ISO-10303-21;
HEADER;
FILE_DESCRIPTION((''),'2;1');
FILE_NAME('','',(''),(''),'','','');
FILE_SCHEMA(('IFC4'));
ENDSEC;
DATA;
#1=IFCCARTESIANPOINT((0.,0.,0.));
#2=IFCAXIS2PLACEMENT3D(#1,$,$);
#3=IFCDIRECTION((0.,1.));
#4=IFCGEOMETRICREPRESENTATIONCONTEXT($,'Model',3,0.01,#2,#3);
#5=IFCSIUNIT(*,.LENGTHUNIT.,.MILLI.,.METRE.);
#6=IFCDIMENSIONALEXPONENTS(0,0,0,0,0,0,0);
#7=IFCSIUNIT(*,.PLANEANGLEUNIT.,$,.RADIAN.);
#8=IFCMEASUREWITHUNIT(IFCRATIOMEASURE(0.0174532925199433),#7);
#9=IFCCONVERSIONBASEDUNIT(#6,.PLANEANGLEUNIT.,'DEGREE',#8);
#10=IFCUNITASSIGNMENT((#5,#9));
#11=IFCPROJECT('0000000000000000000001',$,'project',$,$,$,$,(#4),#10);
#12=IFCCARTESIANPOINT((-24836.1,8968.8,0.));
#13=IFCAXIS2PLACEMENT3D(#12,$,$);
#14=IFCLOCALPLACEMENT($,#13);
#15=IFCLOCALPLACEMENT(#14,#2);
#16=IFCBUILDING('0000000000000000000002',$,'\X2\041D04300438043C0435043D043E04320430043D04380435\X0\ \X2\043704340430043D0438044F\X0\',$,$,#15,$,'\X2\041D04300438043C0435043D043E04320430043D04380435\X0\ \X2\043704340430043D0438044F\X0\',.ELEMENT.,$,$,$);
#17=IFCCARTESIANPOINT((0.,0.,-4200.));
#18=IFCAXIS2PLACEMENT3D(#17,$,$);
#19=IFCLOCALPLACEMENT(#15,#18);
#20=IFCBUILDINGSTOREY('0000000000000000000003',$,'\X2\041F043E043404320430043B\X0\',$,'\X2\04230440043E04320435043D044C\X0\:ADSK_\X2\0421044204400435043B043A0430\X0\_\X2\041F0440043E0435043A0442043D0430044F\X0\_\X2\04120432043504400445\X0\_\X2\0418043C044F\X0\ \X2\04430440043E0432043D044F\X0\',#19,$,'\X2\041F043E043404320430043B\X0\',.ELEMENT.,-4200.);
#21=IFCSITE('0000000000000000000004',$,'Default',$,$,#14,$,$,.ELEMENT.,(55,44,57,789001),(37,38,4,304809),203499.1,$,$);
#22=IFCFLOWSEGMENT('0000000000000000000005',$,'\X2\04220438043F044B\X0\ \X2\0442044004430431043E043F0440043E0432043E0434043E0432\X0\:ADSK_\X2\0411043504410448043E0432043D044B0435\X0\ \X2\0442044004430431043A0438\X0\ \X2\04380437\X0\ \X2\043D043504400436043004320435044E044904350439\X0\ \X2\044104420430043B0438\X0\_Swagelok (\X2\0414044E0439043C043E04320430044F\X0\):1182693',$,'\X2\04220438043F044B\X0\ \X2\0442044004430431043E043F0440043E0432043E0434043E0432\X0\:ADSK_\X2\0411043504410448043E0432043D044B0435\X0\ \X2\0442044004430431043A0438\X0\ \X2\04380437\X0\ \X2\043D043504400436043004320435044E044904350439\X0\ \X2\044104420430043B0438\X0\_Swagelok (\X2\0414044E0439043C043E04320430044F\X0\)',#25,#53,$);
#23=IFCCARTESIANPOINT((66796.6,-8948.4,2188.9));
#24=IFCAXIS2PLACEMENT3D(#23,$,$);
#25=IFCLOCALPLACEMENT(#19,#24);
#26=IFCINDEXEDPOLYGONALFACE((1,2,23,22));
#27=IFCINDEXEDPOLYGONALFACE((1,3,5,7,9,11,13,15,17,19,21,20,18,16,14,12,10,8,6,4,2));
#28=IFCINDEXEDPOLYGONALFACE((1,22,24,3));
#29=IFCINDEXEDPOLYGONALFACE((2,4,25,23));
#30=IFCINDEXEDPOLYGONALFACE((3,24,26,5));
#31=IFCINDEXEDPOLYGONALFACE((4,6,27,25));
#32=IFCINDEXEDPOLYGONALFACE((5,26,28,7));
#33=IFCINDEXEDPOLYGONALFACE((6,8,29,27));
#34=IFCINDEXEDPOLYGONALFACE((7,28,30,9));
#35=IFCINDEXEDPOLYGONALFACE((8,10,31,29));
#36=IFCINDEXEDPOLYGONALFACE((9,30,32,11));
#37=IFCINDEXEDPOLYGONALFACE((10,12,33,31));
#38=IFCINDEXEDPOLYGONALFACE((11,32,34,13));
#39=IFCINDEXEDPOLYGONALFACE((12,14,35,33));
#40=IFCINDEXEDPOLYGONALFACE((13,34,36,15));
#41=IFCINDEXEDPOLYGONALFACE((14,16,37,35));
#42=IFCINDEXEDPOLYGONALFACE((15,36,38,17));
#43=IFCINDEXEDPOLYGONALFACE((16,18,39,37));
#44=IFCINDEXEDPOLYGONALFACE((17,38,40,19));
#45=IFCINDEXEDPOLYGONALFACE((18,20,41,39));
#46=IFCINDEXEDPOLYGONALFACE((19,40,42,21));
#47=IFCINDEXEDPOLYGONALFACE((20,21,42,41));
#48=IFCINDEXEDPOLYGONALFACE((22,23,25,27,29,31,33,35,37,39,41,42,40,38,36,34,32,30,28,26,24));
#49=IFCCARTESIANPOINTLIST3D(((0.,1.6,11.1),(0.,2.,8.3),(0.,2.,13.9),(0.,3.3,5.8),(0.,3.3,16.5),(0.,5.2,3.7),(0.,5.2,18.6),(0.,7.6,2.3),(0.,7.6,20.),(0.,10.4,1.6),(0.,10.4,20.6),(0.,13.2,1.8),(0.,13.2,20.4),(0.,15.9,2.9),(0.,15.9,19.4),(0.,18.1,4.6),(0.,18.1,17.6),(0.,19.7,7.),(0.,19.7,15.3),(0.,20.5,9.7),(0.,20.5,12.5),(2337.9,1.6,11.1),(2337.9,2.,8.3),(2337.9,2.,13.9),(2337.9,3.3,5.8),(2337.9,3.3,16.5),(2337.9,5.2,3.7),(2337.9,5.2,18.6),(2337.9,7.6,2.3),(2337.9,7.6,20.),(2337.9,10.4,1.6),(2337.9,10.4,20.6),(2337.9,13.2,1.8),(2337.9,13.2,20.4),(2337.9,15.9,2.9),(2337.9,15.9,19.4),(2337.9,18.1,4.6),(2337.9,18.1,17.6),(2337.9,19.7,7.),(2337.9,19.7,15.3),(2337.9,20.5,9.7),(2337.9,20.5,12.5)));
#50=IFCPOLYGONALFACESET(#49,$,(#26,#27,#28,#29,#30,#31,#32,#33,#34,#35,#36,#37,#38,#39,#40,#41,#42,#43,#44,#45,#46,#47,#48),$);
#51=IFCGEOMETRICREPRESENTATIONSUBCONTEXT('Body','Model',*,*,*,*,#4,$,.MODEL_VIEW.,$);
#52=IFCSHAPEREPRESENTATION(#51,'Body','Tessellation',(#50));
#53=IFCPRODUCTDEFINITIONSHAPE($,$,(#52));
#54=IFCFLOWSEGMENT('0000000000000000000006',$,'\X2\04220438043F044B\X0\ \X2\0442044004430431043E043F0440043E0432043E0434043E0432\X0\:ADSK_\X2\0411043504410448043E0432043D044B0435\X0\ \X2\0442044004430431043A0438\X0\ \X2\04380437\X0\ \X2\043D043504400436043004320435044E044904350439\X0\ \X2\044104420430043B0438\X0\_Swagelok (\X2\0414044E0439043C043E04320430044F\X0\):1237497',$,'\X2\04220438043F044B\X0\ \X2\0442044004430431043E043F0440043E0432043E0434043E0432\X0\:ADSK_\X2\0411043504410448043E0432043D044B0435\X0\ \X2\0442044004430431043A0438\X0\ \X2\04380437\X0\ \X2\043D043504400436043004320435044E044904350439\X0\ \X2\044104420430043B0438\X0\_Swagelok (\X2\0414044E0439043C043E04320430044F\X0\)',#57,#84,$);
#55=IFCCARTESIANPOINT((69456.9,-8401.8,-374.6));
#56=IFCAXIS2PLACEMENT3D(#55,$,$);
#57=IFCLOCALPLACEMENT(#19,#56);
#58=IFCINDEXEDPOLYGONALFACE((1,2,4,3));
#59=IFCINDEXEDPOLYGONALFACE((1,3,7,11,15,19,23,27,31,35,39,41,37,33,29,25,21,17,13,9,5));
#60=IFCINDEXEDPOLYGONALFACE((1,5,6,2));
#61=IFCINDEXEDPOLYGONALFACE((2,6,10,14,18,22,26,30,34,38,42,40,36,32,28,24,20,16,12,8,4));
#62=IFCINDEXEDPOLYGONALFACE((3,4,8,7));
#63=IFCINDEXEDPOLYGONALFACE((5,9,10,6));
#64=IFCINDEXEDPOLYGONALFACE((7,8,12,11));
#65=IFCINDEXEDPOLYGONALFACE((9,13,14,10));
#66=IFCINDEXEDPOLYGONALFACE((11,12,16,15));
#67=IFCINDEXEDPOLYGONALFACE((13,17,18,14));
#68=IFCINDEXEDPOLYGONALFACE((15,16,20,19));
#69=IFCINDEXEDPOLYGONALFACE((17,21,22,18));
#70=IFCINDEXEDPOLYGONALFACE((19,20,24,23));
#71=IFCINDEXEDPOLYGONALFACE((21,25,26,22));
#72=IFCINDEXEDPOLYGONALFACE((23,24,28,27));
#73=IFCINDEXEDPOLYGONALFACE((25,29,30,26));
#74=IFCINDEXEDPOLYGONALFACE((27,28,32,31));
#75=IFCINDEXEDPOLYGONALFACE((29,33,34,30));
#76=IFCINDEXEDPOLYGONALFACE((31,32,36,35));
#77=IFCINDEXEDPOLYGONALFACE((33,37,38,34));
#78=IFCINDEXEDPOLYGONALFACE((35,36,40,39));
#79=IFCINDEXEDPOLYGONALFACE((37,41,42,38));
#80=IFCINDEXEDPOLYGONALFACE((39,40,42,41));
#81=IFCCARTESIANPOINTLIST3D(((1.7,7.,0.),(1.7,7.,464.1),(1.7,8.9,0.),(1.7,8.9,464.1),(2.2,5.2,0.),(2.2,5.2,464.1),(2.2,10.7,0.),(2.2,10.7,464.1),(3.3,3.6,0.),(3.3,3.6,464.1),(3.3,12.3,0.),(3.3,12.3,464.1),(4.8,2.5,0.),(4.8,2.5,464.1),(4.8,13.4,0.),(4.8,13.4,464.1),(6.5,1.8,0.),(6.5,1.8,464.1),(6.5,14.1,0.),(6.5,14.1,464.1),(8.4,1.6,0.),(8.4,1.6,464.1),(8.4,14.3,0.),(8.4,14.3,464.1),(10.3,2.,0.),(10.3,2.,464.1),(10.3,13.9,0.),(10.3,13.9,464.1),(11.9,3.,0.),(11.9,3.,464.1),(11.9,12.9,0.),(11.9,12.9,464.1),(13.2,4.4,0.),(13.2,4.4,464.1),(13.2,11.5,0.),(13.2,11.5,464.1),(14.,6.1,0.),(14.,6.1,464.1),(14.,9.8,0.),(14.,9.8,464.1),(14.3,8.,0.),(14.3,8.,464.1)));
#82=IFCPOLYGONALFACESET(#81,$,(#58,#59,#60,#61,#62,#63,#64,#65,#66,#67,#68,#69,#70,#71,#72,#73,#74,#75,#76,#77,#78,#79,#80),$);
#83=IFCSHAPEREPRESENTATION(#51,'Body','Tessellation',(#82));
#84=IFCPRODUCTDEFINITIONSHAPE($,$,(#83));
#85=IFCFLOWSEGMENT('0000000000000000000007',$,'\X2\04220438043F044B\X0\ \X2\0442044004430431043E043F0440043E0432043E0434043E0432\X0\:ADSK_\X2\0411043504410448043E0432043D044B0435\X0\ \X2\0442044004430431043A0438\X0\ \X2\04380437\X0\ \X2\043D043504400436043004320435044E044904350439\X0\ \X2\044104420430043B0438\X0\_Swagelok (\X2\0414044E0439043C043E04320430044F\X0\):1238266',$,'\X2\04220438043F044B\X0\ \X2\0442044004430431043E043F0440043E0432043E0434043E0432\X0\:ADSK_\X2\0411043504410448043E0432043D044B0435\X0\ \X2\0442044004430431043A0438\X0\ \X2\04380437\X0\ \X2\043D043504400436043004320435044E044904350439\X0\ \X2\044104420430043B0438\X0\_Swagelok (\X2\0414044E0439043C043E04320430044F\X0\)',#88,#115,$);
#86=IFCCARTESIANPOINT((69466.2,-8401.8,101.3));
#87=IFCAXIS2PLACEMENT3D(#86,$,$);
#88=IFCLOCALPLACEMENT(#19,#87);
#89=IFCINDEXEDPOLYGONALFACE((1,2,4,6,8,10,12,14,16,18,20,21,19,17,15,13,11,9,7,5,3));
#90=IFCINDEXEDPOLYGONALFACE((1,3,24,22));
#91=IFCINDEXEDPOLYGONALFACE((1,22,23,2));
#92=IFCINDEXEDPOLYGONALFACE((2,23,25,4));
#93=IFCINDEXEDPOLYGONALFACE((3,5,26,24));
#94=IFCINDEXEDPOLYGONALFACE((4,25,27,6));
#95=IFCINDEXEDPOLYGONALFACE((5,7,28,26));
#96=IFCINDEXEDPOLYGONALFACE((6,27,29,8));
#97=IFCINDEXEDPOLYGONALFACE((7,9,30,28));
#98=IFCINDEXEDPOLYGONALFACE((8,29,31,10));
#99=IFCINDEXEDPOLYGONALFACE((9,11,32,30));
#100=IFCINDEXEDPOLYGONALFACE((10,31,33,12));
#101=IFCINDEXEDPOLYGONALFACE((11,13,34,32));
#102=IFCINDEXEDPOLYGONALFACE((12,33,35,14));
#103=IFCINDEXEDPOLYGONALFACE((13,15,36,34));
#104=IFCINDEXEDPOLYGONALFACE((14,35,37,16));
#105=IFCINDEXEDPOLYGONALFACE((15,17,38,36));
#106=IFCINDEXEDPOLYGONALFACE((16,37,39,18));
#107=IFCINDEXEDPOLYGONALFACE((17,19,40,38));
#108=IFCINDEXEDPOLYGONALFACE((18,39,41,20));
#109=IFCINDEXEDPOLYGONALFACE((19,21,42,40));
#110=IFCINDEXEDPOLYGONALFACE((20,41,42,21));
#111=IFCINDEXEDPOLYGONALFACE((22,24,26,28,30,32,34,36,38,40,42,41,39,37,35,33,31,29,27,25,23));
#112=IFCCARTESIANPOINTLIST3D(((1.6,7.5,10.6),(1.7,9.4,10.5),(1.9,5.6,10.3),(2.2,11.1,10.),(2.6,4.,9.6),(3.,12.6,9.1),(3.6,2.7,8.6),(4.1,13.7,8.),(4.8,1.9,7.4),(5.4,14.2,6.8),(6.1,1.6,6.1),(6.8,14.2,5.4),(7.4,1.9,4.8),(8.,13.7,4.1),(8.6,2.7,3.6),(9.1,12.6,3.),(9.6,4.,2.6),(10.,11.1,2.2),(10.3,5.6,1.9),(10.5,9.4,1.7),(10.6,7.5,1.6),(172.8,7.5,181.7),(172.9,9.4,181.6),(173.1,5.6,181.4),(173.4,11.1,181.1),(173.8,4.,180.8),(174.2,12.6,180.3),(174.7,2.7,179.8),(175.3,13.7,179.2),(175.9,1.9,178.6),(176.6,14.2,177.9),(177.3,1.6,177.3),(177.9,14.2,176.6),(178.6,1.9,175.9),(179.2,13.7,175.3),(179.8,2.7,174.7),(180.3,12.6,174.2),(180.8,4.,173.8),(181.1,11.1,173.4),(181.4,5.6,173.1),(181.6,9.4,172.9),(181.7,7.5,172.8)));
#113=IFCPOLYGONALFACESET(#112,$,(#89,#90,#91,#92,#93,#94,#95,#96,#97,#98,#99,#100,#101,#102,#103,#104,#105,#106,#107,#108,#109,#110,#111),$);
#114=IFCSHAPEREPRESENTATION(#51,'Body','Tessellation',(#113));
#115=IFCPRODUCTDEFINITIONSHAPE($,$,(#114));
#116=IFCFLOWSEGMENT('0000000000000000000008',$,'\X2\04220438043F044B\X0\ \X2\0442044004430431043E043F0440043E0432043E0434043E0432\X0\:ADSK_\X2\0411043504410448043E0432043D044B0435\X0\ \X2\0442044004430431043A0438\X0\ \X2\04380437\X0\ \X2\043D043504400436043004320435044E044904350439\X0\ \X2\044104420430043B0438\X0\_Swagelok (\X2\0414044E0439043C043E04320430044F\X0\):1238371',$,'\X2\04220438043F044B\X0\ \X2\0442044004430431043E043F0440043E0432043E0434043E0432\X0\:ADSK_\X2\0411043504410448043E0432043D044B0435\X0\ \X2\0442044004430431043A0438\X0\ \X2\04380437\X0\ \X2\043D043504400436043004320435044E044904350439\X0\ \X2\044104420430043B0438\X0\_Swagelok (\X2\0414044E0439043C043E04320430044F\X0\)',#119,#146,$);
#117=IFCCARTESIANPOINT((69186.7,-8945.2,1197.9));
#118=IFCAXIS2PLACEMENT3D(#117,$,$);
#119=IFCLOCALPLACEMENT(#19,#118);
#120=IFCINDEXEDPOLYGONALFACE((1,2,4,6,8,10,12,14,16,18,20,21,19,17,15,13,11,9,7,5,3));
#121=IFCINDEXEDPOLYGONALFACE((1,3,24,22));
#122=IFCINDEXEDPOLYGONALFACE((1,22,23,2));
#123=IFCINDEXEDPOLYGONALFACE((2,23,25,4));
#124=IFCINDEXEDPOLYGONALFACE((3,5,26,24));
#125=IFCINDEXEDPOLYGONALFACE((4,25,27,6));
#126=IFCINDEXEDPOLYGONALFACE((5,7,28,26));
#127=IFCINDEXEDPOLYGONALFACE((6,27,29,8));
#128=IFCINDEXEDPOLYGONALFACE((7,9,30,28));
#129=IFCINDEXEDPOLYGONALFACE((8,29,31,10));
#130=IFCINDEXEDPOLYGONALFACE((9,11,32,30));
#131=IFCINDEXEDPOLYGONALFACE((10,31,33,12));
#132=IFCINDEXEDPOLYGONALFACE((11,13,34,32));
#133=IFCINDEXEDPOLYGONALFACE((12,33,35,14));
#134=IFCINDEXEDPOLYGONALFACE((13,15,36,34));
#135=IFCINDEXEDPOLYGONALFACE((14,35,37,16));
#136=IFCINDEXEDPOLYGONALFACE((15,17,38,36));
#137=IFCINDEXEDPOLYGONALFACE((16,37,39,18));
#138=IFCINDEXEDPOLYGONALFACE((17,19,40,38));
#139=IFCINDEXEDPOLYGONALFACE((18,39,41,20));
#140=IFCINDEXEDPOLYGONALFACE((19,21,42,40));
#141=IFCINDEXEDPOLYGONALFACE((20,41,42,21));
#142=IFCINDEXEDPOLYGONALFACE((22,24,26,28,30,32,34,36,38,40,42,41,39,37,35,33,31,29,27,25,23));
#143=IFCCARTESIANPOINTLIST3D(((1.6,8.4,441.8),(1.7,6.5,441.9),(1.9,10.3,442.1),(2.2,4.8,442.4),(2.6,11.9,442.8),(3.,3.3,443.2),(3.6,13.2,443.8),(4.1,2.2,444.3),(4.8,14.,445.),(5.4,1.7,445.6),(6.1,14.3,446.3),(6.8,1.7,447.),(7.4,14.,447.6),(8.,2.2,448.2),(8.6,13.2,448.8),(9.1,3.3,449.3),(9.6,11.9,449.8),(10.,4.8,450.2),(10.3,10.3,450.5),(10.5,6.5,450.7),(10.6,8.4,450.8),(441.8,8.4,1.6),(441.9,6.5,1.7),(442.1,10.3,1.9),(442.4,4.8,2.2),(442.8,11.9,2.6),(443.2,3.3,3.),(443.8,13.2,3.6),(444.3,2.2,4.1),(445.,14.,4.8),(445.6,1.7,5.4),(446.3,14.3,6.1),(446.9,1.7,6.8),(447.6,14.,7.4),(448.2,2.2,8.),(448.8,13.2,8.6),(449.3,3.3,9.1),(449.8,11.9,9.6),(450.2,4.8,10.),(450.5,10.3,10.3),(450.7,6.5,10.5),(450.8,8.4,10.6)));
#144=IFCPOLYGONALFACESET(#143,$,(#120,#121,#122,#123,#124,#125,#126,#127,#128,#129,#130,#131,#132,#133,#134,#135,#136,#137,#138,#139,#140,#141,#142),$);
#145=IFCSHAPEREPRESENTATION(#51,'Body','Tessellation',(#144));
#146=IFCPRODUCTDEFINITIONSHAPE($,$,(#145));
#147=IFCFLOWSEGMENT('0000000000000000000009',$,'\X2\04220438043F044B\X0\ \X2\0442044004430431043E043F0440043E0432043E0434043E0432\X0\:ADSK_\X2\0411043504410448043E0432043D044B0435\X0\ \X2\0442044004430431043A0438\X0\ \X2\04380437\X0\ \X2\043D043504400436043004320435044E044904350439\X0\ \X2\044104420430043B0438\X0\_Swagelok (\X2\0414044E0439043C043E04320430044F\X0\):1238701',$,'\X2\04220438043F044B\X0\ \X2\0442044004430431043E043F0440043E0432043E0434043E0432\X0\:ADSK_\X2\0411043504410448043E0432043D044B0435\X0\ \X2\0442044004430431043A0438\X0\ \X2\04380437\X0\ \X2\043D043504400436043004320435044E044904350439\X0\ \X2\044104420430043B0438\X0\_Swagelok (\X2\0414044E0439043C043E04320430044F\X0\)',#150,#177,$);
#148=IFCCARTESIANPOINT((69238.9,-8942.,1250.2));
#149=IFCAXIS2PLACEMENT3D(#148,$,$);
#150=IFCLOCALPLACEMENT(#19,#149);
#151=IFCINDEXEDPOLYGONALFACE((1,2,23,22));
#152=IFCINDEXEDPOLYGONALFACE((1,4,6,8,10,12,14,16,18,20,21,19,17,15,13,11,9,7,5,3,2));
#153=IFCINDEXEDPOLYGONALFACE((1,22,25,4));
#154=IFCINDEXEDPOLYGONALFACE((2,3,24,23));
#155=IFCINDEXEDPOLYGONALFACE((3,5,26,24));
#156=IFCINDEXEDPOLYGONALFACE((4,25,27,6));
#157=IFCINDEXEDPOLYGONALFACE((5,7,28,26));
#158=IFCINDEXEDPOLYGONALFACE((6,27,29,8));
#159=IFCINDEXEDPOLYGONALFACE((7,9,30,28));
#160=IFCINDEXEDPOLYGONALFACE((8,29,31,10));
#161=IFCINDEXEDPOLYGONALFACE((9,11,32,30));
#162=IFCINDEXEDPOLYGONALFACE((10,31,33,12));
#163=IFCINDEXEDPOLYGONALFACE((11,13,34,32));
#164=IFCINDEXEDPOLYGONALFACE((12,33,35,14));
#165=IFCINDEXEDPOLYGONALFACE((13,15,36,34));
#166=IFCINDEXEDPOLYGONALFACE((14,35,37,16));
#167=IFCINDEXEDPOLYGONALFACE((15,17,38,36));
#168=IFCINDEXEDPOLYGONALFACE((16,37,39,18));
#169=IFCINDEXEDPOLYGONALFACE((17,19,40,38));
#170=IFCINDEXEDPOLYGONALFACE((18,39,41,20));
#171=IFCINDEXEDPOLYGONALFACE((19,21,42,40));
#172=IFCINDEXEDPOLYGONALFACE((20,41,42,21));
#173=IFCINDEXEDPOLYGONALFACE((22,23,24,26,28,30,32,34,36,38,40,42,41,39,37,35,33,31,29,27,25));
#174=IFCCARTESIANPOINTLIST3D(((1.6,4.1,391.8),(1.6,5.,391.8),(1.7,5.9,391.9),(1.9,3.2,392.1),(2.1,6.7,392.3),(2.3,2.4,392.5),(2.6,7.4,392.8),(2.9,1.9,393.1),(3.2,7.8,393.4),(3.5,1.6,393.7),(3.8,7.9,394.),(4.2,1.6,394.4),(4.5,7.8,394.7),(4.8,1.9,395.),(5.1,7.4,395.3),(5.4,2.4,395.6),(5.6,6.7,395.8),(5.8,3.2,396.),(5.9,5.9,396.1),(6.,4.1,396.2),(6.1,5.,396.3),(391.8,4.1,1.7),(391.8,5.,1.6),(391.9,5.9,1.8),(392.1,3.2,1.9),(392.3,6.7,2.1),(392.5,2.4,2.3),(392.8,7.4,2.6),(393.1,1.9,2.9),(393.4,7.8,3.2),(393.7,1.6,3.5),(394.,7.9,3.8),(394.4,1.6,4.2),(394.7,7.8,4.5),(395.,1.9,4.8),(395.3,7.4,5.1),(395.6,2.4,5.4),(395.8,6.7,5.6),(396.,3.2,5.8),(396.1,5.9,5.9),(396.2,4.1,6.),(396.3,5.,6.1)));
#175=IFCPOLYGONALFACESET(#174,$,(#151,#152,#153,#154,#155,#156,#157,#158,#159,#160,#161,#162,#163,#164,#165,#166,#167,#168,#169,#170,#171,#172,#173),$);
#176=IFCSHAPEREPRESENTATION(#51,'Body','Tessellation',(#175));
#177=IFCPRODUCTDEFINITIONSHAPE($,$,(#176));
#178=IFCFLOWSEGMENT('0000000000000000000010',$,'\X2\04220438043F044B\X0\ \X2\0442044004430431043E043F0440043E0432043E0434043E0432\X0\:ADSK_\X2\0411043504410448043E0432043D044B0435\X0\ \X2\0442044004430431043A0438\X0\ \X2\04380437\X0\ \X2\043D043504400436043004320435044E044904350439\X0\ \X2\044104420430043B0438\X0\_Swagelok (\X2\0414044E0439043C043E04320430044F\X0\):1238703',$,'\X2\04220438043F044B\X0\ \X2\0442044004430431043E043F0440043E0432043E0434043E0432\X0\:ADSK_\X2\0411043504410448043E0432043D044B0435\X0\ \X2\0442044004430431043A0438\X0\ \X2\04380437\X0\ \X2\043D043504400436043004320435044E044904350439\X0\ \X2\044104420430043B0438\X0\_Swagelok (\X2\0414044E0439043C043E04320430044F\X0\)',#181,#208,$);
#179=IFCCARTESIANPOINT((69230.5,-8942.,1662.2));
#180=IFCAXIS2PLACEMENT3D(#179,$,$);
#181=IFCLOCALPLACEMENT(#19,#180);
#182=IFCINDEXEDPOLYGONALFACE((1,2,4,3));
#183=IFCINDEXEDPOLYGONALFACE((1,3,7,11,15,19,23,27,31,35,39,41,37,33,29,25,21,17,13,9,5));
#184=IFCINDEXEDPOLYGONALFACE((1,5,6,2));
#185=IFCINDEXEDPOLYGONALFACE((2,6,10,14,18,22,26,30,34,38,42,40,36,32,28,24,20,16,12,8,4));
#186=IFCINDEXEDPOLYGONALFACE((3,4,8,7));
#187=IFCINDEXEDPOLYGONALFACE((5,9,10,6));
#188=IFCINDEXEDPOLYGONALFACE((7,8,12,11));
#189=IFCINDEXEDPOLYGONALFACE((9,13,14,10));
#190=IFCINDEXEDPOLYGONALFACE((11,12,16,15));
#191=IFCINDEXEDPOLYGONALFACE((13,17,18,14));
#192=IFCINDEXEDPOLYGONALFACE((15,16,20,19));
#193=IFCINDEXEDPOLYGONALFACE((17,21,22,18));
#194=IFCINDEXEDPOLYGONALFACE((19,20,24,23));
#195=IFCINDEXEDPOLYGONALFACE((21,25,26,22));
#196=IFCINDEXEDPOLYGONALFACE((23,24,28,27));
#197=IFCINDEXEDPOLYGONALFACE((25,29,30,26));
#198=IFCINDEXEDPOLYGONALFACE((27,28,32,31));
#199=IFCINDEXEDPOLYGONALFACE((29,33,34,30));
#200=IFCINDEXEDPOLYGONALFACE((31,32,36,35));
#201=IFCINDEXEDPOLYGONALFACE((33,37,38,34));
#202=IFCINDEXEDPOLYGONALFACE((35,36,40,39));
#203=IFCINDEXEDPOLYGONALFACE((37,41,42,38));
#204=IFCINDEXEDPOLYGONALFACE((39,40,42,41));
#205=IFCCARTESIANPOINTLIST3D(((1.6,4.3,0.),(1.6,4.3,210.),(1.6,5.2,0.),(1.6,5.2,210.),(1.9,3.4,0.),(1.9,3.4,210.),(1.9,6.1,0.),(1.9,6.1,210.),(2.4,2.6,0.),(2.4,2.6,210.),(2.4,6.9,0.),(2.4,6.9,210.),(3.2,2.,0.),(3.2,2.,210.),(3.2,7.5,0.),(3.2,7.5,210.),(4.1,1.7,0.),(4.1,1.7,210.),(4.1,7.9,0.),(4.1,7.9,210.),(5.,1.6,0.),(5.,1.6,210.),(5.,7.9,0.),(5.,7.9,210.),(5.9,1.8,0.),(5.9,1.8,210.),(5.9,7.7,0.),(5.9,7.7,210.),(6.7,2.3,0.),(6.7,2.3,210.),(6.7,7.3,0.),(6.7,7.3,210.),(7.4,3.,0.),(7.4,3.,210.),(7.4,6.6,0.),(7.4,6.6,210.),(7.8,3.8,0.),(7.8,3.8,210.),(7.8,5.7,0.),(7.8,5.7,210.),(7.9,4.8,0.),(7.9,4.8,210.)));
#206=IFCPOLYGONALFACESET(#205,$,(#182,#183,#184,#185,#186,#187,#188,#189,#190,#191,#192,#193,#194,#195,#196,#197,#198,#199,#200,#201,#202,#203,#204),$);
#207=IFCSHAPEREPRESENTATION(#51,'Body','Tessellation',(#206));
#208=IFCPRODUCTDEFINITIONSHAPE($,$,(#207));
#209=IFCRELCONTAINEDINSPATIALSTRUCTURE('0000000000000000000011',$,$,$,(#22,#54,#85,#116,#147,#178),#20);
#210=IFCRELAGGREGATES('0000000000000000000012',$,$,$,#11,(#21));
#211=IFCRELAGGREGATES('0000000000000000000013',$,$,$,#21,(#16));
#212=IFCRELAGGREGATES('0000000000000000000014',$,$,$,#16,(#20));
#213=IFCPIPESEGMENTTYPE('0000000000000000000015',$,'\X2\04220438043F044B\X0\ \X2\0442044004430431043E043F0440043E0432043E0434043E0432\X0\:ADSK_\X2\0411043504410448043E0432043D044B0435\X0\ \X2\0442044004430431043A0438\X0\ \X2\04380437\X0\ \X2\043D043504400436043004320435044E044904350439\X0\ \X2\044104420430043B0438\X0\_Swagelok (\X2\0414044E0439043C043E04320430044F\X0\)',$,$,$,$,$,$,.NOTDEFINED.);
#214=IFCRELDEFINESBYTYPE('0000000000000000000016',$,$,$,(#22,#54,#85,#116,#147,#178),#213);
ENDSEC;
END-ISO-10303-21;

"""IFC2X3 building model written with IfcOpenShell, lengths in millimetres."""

from ifc_helpers import new_model, entity, si_unit, converted_unit, direction, frame, origin, origin_2d_with_axis, place, context, subcontext, project, spatial, circle, extrude, type_object, element, save


model = new_model("IFC2X3")

# Units and contexts
model_context = context("Model", 3, precision=0.01, world=origin(), true_north=direction((0.0, 1.0)))
body_context = subcontext(model_context, "Body", "Model", "MODEL_VIEW")
ifc_project = project(units=[si_unit("LENGTHUNIT", "METRE", prefix="MILLI"), converted_unit("PLANEANGLEUNIT", "DEGREE", entity("IfcRatioMeasure", 0.0174532925199433), si_unit("PLANEANGLEUNIT", "RADIAN"), dimensions=[0, 0, 0, 0, 0, 0, 0])], contexts=[model_context])

# Site, building, storey
site_placement = place(None, frame((-24836.1, 8968.8, 0.0)))
site = spatial("IfcSite", under=ifc_project, at=site_placement, Name="Default", CompositionType="ELEMENT", RefLatitude=(55, 44, 57, 789001), RefLongitude=(37, 38, 4, 304809), RefElevation=203499.1)
building_placement = place(site_placement, origin())
building = spatial("IfcBuilding", under=site, at=building_placement, Name="Наименование здания", LongName="Наименование здания", CompositionType="ELEMENT")
storey_placement = place(building_placement, frame((0.0, 0.0, -4200.0)))
storey = spatial("IfcBuildingStorey", under=building, at=storey_placement, Name="Подвал", ObjectType="Уровень:ADSK_Стрелка_Проектная_Вверх_Имя уровня", LongName="Подвал", CompositionType="ELEMENT", Elevation=-4200.0)

# Flow segments
pipe_segment_type = type_object("IfcPipeSegmentType", Name="Типы трубопроводов:ADSK_Бесшовные трубки из нержавеющей стали_Swagelok (Дюймовая)", PredefinedType="NOTDEFINED")
flow_segment_1_placement = place(storey_placement, frame((66796.6, -8948.4, 2188.9)))
element("IfcFlowSegment", 1, at=flow_segment_1_placement, inside=storey, type_object=pipe_segment_type, Name="Типы трубопроводов:ADSK_Бесшовные трубки из нержавеющей стали_Swagelok (Дюймовая):1182693", ObjectType="Типы трубопроводов:ADSK_Бесшовные трубки из нержавеющей стали_Swagelok (Дюймовая)", context=body_context, shape_type="SweptSolid", body=[
    extrude(circle(Radius=9.5, at=origin_2d_with_axis()), frame((0.0, 11.1, 11.1), z_axis=(1.0, 0.0, 0.0), x_axis=(0.0, -1.0, 0.0)), (0.0, 0.0, 1.0), 2337.9),
])
flow_segment_2_placement = place(storey_placement, frame((69456.9, -8401.8, -374.6)))
element("IfcFlowSegment", 2, at=flow_segment_2_placement, inside=storey, type_object=pipe_segment_type, Name="Типы трубопроводов:ADSK_Бесшовные трубки из нержавеющей стали_Swagelok (Дюймовая):1237497", ObjectType="Типы трубопроводов:ADSK_Бесшовные трубки из нержавеющей стали_Swagelok (Дюймовая)", context=body_context, shape_type="SweptSolid", body=[
    extrude(circle(Radius=6.3, at=origin_2d_with_axis()), frame((8.0, 8.0, 0.0)), (0.0, 0.0, 1.0), 464.1),
])
flow_segment_3_placement = place(storey_placement, frame((69466.2, -8401.8, 101.3)))
element("IfcFlowSegment", 3, at=flow_segment_3_placement, inside=storey, type_object=pipe_segment_type, Name="Типы трубопроводов:ADSK_Бесшовные трубки из нержавеющей стали_Swagelok (Дюймовая):1238266", ObjectType="Типы трубопроводов:ADSK_Бесшовные трубки из нержавеющей стали_Swagelok (Дюймовая)", context=body_context, shape_type="SweptSolid", body=[
    extrude(circle(Radius=6.3, at=origin_2d_with_axis()), frame((6.1, 8.0, 6.1), z_axis=(0.707107, 0.0, 0.707107), x_axis=(0.0, -1.0, 0.0)), (0.0, 0.0, 1.0), 242.1),
])
flow_segment_4_placement = place(storey_placement, frame((69186.7, -8945.2, 1197.9)))
element("IfcFlowSegment", 4, at=flow_segment_4_placement, inside=storey, type_object=pipe_segment_type, Name="Типы трубопроводов:ADSK_Бесшовные трубки из нержавеющей стали_Swagelok (Дюймовая):1238371", ObjectType="Типы трубопроводов:ADSK_Бесшовные трубки из нержавеющей стали_Swagelok (Дюймовая)", context=body_context, shape_type="SweptSolid", body=[
    extrude(circle(Radius=6.3, at=origin_2d_with_axis()), frame((446.3, 8.0, 6.1), z_axis=(-0.707107, 0.0, 0.707107), x_axis=(0.0, 1.0, 0.0)), (0.0, 0.0, 1.0), 622.5),
])
flow_segment_5_placement = place(storey_placement, frame((69238.9, -8942.0, 1250.2)))
element("IfcFlowSegment", 5, at=flow_segment_5_placement, inside=storey, type_object=pipe_segment_type, Name="Типы трубопроводов:ADSK_Бесшовные трубки из нержавеющей стали_Swagelok (Дюймовая):1238701", ObjectType="Типы трубопроводов:ADSK_Бесшовные трубки из нержавеющей стали_Swagelok (Дюймовая)", context=body_context, shape_type="SweptSolid", body=[
    extrude(circle(Radius=3.2, at=origin_2d_with_axis()), frame((394.0, 4.8, 3.8), z_axis=(-0.707107, 0.0, 0.707107), x_axis=(0.0, 1.0, 0.0)), (0.0, 0.0, 1.0), 551.8),
])
flow_segment_6_placement = place(storey_placement, frame((69230.5, -8942.0, 1662.2)))
element("IfcFlowSegment", 6, at=flow_segment_6_placement, inside=storey, type_object=pipe_segment_type, Name="Типы трубопроводов:ADSK_Бесшовные трубки из нержавеющей стали_Swagelok (Дюймовая):1238703", ObjectType="Типы трубопроводов:ADSK_Бесшовные трубки из нержавеющей стали_Swagelok (Дюймовая)", context=body_context, shape_type="SweptSolid", body=[
    extrude(circle(Radius=3.2, at=origin_2d_with_axis()), frame((4.8, 4.8, 0.0)), (0.0, 0.0, 1.0), 210.0),
])

save(model, "model.ifc")
